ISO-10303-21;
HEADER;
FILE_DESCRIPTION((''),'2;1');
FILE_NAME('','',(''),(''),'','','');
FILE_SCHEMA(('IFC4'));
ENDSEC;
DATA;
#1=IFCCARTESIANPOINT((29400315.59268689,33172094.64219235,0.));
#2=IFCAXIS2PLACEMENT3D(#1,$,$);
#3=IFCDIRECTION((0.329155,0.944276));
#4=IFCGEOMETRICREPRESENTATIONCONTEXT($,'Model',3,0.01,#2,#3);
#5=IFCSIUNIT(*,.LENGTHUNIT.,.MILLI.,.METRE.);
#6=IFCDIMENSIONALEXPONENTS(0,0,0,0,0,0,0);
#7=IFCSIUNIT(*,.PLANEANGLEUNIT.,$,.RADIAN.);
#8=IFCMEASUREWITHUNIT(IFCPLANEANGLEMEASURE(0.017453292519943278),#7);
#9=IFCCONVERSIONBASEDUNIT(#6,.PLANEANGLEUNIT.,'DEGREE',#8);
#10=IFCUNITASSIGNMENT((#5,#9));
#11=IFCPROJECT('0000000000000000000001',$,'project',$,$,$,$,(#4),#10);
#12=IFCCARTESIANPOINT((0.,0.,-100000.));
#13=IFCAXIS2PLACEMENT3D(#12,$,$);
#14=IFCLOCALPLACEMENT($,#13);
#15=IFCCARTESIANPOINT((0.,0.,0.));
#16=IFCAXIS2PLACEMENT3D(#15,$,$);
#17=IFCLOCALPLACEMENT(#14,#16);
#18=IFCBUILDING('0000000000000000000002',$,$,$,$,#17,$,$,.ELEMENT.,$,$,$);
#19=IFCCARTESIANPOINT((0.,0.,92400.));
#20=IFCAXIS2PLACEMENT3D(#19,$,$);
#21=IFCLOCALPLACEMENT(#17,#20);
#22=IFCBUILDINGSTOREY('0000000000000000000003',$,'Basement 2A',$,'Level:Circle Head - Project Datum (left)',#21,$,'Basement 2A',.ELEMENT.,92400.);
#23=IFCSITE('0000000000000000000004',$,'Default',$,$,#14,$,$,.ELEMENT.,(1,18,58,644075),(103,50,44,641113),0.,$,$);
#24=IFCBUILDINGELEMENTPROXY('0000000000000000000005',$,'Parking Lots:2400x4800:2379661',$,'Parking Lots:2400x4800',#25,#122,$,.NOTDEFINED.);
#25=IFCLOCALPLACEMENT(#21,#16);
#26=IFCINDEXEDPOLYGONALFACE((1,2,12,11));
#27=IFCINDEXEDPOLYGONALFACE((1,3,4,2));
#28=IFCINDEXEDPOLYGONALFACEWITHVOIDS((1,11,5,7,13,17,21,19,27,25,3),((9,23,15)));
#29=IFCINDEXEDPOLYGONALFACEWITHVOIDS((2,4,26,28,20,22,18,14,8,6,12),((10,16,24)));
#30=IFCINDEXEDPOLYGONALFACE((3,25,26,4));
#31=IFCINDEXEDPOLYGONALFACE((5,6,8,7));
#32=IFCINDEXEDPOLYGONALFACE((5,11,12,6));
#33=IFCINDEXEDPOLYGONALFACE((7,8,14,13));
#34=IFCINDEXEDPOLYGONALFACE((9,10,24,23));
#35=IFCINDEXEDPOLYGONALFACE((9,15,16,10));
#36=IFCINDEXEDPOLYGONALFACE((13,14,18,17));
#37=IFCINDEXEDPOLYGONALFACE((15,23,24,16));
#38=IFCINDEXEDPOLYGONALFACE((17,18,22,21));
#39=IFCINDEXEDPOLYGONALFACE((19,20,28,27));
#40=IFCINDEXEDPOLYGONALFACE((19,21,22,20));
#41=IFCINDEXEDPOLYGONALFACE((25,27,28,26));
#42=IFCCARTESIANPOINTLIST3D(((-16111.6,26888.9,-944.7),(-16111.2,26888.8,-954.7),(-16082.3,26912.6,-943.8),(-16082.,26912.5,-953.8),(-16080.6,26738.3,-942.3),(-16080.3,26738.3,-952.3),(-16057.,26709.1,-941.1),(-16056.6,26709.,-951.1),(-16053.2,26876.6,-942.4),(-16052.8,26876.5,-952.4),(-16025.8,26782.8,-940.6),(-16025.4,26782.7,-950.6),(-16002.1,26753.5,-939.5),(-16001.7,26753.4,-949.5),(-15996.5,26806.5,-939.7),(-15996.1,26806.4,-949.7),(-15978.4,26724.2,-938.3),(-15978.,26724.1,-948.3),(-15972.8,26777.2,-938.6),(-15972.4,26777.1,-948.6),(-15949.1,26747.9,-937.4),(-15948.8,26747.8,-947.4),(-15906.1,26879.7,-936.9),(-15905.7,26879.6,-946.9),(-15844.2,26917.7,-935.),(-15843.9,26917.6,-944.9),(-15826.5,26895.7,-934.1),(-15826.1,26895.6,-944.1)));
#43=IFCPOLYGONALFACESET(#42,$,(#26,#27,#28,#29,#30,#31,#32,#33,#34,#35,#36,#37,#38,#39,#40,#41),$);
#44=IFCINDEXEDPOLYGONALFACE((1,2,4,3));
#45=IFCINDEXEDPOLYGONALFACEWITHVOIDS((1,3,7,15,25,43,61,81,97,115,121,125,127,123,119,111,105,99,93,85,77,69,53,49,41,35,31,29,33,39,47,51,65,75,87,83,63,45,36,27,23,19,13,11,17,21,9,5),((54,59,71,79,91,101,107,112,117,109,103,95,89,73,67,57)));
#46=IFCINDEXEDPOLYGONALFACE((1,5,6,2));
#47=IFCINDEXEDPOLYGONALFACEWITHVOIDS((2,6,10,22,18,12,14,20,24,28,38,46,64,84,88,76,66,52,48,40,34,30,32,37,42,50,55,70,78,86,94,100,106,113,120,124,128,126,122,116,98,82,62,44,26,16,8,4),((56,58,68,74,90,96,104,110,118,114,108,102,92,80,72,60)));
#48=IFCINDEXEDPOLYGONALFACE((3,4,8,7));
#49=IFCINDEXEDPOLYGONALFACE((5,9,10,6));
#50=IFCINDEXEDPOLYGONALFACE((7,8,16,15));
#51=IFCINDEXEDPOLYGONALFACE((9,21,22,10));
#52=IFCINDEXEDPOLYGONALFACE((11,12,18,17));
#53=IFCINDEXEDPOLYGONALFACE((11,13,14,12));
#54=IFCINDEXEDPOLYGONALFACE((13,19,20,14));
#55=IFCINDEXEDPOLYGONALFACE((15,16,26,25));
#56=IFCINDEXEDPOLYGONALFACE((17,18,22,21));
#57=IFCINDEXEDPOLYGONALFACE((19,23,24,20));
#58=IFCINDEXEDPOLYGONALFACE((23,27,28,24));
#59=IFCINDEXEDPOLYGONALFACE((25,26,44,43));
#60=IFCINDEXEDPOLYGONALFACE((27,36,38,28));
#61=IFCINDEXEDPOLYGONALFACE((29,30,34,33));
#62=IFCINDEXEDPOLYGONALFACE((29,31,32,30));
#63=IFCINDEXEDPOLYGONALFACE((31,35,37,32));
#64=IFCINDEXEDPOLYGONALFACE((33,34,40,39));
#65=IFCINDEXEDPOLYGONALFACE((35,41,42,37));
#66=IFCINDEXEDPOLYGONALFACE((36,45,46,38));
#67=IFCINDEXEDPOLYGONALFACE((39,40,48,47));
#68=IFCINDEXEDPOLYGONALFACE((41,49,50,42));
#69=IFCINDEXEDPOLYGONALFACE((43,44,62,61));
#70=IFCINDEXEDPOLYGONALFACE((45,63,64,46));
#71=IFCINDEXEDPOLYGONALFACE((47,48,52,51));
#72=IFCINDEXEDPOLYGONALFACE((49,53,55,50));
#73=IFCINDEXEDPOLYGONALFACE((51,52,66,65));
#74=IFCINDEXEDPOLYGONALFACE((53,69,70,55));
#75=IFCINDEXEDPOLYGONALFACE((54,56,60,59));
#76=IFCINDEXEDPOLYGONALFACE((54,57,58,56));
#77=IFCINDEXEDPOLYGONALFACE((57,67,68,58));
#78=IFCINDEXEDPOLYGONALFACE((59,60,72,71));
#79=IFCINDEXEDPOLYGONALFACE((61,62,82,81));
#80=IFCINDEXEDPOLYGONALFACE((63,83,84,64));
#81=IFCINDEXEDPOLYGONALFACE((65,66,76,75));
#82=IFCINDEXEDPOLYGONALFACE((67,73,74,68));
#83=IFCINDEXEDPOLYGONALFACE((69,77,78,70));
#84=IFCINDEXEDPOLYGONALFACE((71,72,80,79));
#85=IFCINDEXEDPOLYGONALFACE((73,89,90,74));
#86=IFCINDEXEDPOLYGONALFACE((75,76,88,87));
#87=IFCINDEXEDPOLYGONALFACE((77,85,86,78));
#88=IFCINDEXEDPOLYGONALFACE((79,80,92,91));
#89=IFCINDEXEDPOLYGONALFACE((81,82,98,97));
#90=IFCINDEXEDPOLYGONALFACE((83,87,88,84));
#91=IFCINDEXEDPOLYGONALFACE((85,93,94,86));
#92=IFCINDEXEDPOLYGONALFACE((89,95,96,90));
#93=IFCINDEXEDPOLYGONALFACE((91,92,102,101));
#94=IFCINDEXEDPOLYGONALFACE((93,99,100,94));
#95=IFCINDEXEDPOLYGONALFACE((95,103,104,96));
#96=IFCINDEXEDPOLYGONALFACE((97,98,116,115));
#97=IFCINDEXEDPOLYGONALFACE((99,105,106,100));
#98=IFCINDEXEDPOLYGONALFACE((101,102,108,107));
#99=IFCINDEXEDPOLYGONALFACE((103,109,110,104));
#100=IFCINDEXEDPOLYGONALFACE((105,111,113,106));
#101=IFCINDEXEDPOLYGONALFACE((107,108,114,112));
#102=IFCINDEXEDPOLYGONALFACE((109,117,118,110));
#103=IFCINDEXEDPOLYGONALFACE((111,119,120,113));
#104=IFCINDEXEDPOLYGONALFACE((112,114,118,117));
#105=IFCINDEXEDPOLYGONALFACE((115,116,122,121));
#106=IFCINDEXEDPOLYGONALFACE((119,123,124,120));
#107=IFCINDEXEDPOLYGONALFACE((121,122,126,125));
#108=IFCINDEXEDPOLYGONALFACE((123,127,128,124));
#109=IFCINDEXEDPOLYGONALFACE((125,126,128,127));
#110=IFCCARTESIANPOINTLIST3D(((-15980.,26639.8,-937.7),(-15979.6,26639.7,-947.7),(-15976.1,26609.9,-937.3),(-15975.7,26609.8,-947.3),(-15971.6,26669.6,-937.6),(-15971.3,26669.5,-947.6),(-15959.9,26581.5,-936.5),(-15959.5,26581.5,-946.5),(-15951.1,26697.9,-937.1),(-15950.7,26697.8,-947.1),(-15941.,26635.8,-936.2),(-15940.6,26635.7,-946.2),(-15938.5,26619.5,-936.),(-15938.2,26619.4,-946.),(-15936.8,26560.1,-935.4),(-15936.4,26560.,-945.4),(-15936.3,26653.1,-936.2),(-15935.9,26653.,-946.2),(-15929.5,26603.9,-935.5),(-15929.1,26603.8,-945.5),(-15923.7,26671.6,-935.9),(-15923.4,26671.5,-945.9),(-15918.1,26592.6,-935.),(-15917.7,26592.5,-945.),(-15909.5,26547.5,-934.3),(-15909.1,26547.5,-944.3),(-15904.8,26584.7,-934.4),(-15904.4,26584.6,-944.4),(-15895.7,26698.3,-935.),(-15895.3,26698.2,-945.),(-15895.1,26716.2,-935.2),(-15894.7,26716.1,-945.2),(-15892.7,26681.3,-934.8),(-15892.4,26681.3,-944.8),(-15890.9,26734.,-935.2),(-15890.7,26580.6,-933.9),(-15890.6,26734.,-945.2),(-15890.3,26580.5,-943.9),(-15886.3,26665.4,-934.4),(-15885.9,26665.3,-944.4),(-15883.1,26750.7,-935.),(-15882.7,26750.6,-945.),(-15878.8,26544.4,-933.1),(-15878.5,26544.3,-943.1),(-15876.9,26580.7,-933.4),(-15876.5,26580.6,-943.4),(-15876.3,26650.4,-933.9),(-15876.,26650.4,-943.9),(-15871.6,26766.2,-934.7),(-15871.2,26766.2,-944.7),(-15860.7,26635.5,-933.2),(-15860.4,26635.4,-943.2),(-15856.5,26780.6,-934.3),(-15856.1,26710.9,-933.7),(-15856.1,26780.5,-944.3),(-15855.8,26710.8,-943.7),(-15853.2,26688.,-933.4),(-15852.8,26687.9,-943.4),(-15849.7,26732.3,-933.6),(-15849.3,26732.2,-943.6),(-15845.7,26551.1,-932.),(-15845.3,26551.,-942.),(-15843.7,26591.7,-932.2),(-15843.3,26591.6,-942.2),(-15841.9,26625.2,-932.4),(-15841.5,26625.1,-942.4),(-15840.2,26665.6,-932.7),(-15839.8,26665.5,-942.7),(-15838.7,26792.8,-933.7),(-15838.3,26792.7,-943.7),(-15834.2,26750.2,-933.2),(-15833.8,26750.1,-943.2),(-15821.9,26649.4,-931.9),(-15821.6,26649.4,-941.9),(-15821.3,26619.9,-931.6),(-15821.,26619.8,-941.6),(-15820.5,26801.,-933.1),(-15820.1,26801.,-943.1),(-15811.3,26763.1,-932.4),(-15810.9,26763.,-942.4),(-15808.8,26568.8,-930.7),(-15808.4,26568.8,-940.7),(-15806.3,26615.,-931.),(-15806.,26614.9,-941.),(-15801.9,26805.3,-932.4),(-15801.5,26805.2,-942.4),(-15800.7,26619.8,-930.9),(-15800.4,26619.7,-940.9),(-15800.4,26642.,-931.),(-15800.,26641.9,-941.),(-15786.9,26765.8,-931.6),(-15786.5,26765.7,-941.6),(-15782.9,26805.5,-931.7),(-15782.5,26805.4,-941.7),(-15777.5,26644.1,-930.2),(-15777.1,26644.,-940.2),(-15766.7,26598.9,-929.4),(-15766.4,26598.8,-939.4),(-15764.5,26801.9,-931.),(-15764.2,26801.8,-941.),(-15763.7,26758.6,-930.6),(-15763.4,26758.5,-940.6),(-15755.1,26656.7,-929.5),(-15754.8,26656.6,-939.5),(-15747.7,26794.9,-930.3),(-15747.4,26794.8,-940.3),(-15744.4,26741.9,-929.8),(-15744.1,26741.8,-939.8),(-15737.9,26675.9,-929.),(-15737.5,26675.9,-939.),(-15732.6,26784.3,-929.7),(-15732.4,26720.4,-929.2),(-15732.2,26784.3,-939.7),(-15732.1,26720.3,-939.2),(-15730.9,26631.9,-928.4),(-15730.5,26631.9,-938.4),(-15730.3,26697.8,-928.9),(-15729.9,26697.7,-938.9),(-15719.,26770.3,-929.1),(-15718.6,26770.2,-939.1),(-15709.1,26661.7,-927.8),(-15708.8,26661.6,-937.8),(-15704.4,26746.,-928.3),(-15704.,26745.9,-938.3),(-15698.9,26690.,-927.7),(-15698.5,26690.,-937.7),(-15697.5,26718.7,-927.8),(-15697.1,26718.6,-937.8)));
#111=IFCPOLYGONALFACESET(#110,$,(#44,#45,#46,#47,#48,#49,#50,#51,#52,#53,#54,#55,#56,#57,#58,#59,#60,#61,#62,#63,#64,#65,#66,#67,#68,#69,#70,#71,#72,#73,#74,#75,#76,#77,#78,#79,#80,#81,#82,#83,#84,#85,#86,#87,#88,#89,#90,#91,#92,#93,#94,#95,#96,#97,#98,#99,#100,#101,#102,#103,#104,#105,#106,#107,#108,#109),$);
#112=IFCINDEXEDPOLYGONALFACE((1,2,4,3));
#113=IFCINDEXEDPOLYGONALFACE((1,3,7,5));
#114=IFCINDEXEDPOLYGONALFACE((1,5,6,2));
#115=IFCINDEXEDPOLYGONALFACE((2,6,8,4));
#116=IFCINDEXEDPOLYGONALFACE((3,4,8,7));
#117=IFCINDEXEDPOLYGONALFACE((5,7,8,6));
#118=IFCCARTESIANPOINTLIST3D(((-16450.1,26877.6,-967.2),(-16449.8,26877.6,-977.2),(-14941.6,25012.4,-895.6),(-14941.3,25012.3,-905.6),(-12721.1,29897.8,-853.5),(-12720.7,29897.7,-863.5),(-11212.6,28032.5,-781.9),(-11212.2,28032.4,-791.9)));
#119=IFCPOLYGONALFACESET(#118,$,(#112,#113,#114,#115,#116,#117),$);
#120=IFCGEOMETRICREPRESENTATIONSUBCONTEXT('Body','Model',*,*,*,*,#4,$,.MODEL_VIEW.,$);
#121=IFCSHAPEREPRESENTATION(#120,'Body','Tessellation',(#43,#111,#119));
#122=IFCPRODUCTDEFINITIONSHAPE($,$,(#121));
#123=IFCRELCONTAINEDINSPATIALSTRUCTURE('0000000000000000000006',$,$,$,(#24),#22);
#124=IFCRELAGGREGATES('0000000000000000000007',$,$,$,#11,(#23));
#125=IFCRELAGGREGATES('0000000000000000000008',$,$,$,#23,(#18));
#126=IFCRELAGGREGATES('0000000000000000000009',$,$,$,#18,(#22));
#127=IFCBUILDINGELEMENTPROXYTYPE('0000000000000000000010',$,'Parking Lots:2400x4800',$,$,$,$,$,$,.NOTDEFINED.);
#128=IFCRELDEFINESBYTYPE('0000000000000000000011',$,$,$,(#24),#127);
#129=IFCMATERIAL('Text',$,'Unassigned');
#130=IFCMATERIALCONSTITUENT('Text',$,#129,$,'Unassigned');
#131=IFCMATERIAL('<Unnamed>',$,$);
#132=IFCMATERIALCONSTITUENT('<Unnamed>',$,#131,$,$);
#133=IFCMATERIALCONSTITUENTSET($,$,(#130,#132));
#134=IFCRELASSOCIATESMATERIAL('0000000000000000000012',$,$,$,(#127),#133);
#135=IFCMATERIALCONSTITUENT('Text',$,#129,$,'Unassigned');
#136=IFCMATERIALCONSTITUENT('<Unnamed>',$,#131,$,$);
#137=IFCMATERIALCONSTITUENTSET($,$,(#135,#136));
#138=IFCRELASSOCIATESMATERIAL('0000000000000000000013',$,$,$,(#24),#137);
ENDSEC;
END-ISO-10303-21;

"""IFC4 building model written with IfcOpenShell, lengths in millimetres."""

from ifc_helpers import new_model, entity, si_unit, converted_unit, direction, frame, origin, place, context, subcontext, project, spatial, indexed_curve, outline, extrude, source, transform, mapped, material, constituent, constituent_set, type_object, type_shapes, element, save


model = new_model("IFC4")

# Units and contexts
model_context = context("Model", 3, precision=0.01, world=frame((29400315.59268689, 33172094.64219235, 0.0)), true_north=direction((0.329155, 0.944276)))
body_context = subcontext(model_context, "Body", "Model", "MODEL_VIEW")
ifc_project = project(units=[si_unit("LENGTHUNIT", "METRE", prefix="MILLI"), converted_unit("PLANEANGLEUNIT", "DEGREE", entity("IfcPlaneAngleMeasure", 0.017453292519943278), si_unit("PLANEANGLEUNIT", "RADIAN"), dimensions=[0, 0, 0, 0, 0, 0, 0])], contexts=[model_context])

# Site, building, storey
site_placement = place(None, frame((0.0, 0.0, -100000.0)))
site = spatial("IfcSite", under=ifc_project, at=site_placement, Name="Default", CompositionType="ELEMENT", RefLatitude=(1, 18, 58, 644075), RefLongitude=(103, 50, 44, 641113), RefElevation=0.0)
building_placement = place(site_placement, origin())
building = spatial("IfcBuilding", under=site, at=building_placement, CompositionType="ELEMENT")
storey_placement = place(building_placement, frame((0.0, 0.0, 92400.0)))
storey = spatial("IfcBuildingStorey", under=building, at=storey_placement, Name="Basement 2A", ObjectType="Level:Circle Head - Project Datum (left)", LongName="Basement 2A", CompositionType="ELEMENT", Elevation=92400.0)

# Building element proxy
ifc_material_1 = material(Name="Text", Category="Unassigned")
ifc_material_2 = material(Name="<Unnamed>")
ifc_constituent_1 = constituent(ifc_material_1, Name="Text", Category="Unassigned")
ifc_constituent_2 = constituent(ifc_material_2, Name="<Unnamed>")
ifc_constituent_set_1 = constituent_set(constituents=[ifc_constituent_1, ifc_constituent_2])
ifc_constituent_3 = constituent(ifc_material_1, Name="Text", Category="Unassigned")
ifc_constituent_4 = constituent(ifc_material_2, Name="<Unnamed>")
ifc_constituent_set_2 = constituent_set(constituents=[ifc_constituent_3, ifc_constituent_4])
building_element_proxy_type_1 = type_object("IfcBuildingElementProxyType", Name="Parking Lots:2400x4800", PredefinedType="NOTDEFINED", material=ifc_constituent_set_2)
shared_shape_1 = source(origin(), body_context, "Body", "SweptSolid", [
    extrude(outline(indexed_curve([(-3.4, -109.2), (34.2, -109.2), (34.2, -38.5), (71.9, -38.5), (71.9, -0.9), (34.2, -0.9), (34.2, 187.5), (6.0, 187.5), (-140.0, -0.9), (-140.0, -38.5), (-3.4, -38.5), (-3.4, -109.2)], self_intersect=False), holes=[indexed_curve([(-3.4, -0.9), (-93.6, -0.9), (-3.4, 115.5), (-3.4, -0.9)], self_intersect=False)]), frame((344.7, -4490.8, 10.0)), (0.0, 0.0, 1.0), 10.0),
    extrude(outline(indexed_curve([(33.6, -97.6), (68.6, -97.6), (97.6, -86.8), (119.5, -66.0), (132.9, -36.3), (136.6, -5.0), (130.7, 24.5), (115.2, 51.2), (90.3, 74.0), (54.2, 93.5), (5.1, 109.8), (-42.7, 119.3), (-79.6, 119.4), (-108.5, 111.1), (-132.5, 95.3), (-150.5, 73.7), (-161.5, 47.5), (-164.9, 28.3), (-164.5, 9.8), (-160.3, -7.9), (-152.3, -24.9), (-141.0, -40.1), (-126.6, -52.7), (-109.3, -62.6), (-88.9, -69.7), (-68.4, -73.6), (-49.1, -73.7), (-31.0, -70.3), (-14.1, -63.1), (0.7, -53.0), (12.7, -40.7), (21.8, -26.1), (28.0, -9.2), (30.9, 12.2), (28.1, 33.5), (20.3, 53.3), (8.3, 70.0), (15.4, 68.3), (56.3, 51.8), (84.7, 31.4), (92.9, 20.3), (97.9, 6.5), (99.3, -9.0), (96.9, -24.9), (89.6, -41.3), (77.9, -53.0), (61.1, -59.3), (38.8, -60.0), (33.6, -97.6)], self_intersect=False), holes=[indexed_curve([(-48.4, 85.2), (-25.1, 74.5), (-9.9, 57.2), (-3.2, 35.4), (-5.6, 11.1), (-16.1, -12.6), (-32.8, -28.5), (-53.9, -35.8), (-77.4, -33.8), (-101.4, -22.9), (-117.9, -4.7), (-125.7, 18.2), (-123.6, 43.7), (-113.3, 66.1), (-96.3, 81.1), (-74.2, 87.8), (-48.4, 85.2)], self_intersect=False)]), frame((539.9, -4467.0, 10.0), z_axis=(0.0, 0.0, 1.0), x_axis=(0.258285, -0.966069, 0.0)), (0.0, 0.0, 1.0), 10.0),
    extrude(outline(indexed_curve([(-1200.0, -2400.0), (1200.0, -2400.0), (1200.0, 2400.0), (-1200.0, 2400.0), (-1200.0, -2400.0)], self_intersect=False)), frame((1200.0, -2400.0, 0.0), z_axis=(0.0, 0.0, 1.0), x_axis=(-1.0, 0.0, 0.0)), (0.0, 0.0, 1.0), 10.0),
])
type_shapes(building_element_proxy_type_1, [shared_shape_1])
proxy_1_placement = place(storey_placement, frame((-12720.7, 29897.7, -863.5), z_axis=(-0.037166, 0.008281, 0.999275), x_axis=(0.628546, -0.7772, 0.029818)))
element("IfcBuildingElementProxy", 1, at=proxy_1_placement, inside=storey, type_object=building_element_proxy_type_1, material=ifc_constituent_set_1, Name="Parking Lots:2400x4800:2379661", ObjectType="Parking Lots:2400x4800", PredefinedType="NOTDEFINED", context=body_context, shape_type="MappedRepresentation", body=[
    mapped(shared_shape_1, transform((0.0, 0.0, 0.0), scale=1.0)),
])

save(model, "model.ifc")
